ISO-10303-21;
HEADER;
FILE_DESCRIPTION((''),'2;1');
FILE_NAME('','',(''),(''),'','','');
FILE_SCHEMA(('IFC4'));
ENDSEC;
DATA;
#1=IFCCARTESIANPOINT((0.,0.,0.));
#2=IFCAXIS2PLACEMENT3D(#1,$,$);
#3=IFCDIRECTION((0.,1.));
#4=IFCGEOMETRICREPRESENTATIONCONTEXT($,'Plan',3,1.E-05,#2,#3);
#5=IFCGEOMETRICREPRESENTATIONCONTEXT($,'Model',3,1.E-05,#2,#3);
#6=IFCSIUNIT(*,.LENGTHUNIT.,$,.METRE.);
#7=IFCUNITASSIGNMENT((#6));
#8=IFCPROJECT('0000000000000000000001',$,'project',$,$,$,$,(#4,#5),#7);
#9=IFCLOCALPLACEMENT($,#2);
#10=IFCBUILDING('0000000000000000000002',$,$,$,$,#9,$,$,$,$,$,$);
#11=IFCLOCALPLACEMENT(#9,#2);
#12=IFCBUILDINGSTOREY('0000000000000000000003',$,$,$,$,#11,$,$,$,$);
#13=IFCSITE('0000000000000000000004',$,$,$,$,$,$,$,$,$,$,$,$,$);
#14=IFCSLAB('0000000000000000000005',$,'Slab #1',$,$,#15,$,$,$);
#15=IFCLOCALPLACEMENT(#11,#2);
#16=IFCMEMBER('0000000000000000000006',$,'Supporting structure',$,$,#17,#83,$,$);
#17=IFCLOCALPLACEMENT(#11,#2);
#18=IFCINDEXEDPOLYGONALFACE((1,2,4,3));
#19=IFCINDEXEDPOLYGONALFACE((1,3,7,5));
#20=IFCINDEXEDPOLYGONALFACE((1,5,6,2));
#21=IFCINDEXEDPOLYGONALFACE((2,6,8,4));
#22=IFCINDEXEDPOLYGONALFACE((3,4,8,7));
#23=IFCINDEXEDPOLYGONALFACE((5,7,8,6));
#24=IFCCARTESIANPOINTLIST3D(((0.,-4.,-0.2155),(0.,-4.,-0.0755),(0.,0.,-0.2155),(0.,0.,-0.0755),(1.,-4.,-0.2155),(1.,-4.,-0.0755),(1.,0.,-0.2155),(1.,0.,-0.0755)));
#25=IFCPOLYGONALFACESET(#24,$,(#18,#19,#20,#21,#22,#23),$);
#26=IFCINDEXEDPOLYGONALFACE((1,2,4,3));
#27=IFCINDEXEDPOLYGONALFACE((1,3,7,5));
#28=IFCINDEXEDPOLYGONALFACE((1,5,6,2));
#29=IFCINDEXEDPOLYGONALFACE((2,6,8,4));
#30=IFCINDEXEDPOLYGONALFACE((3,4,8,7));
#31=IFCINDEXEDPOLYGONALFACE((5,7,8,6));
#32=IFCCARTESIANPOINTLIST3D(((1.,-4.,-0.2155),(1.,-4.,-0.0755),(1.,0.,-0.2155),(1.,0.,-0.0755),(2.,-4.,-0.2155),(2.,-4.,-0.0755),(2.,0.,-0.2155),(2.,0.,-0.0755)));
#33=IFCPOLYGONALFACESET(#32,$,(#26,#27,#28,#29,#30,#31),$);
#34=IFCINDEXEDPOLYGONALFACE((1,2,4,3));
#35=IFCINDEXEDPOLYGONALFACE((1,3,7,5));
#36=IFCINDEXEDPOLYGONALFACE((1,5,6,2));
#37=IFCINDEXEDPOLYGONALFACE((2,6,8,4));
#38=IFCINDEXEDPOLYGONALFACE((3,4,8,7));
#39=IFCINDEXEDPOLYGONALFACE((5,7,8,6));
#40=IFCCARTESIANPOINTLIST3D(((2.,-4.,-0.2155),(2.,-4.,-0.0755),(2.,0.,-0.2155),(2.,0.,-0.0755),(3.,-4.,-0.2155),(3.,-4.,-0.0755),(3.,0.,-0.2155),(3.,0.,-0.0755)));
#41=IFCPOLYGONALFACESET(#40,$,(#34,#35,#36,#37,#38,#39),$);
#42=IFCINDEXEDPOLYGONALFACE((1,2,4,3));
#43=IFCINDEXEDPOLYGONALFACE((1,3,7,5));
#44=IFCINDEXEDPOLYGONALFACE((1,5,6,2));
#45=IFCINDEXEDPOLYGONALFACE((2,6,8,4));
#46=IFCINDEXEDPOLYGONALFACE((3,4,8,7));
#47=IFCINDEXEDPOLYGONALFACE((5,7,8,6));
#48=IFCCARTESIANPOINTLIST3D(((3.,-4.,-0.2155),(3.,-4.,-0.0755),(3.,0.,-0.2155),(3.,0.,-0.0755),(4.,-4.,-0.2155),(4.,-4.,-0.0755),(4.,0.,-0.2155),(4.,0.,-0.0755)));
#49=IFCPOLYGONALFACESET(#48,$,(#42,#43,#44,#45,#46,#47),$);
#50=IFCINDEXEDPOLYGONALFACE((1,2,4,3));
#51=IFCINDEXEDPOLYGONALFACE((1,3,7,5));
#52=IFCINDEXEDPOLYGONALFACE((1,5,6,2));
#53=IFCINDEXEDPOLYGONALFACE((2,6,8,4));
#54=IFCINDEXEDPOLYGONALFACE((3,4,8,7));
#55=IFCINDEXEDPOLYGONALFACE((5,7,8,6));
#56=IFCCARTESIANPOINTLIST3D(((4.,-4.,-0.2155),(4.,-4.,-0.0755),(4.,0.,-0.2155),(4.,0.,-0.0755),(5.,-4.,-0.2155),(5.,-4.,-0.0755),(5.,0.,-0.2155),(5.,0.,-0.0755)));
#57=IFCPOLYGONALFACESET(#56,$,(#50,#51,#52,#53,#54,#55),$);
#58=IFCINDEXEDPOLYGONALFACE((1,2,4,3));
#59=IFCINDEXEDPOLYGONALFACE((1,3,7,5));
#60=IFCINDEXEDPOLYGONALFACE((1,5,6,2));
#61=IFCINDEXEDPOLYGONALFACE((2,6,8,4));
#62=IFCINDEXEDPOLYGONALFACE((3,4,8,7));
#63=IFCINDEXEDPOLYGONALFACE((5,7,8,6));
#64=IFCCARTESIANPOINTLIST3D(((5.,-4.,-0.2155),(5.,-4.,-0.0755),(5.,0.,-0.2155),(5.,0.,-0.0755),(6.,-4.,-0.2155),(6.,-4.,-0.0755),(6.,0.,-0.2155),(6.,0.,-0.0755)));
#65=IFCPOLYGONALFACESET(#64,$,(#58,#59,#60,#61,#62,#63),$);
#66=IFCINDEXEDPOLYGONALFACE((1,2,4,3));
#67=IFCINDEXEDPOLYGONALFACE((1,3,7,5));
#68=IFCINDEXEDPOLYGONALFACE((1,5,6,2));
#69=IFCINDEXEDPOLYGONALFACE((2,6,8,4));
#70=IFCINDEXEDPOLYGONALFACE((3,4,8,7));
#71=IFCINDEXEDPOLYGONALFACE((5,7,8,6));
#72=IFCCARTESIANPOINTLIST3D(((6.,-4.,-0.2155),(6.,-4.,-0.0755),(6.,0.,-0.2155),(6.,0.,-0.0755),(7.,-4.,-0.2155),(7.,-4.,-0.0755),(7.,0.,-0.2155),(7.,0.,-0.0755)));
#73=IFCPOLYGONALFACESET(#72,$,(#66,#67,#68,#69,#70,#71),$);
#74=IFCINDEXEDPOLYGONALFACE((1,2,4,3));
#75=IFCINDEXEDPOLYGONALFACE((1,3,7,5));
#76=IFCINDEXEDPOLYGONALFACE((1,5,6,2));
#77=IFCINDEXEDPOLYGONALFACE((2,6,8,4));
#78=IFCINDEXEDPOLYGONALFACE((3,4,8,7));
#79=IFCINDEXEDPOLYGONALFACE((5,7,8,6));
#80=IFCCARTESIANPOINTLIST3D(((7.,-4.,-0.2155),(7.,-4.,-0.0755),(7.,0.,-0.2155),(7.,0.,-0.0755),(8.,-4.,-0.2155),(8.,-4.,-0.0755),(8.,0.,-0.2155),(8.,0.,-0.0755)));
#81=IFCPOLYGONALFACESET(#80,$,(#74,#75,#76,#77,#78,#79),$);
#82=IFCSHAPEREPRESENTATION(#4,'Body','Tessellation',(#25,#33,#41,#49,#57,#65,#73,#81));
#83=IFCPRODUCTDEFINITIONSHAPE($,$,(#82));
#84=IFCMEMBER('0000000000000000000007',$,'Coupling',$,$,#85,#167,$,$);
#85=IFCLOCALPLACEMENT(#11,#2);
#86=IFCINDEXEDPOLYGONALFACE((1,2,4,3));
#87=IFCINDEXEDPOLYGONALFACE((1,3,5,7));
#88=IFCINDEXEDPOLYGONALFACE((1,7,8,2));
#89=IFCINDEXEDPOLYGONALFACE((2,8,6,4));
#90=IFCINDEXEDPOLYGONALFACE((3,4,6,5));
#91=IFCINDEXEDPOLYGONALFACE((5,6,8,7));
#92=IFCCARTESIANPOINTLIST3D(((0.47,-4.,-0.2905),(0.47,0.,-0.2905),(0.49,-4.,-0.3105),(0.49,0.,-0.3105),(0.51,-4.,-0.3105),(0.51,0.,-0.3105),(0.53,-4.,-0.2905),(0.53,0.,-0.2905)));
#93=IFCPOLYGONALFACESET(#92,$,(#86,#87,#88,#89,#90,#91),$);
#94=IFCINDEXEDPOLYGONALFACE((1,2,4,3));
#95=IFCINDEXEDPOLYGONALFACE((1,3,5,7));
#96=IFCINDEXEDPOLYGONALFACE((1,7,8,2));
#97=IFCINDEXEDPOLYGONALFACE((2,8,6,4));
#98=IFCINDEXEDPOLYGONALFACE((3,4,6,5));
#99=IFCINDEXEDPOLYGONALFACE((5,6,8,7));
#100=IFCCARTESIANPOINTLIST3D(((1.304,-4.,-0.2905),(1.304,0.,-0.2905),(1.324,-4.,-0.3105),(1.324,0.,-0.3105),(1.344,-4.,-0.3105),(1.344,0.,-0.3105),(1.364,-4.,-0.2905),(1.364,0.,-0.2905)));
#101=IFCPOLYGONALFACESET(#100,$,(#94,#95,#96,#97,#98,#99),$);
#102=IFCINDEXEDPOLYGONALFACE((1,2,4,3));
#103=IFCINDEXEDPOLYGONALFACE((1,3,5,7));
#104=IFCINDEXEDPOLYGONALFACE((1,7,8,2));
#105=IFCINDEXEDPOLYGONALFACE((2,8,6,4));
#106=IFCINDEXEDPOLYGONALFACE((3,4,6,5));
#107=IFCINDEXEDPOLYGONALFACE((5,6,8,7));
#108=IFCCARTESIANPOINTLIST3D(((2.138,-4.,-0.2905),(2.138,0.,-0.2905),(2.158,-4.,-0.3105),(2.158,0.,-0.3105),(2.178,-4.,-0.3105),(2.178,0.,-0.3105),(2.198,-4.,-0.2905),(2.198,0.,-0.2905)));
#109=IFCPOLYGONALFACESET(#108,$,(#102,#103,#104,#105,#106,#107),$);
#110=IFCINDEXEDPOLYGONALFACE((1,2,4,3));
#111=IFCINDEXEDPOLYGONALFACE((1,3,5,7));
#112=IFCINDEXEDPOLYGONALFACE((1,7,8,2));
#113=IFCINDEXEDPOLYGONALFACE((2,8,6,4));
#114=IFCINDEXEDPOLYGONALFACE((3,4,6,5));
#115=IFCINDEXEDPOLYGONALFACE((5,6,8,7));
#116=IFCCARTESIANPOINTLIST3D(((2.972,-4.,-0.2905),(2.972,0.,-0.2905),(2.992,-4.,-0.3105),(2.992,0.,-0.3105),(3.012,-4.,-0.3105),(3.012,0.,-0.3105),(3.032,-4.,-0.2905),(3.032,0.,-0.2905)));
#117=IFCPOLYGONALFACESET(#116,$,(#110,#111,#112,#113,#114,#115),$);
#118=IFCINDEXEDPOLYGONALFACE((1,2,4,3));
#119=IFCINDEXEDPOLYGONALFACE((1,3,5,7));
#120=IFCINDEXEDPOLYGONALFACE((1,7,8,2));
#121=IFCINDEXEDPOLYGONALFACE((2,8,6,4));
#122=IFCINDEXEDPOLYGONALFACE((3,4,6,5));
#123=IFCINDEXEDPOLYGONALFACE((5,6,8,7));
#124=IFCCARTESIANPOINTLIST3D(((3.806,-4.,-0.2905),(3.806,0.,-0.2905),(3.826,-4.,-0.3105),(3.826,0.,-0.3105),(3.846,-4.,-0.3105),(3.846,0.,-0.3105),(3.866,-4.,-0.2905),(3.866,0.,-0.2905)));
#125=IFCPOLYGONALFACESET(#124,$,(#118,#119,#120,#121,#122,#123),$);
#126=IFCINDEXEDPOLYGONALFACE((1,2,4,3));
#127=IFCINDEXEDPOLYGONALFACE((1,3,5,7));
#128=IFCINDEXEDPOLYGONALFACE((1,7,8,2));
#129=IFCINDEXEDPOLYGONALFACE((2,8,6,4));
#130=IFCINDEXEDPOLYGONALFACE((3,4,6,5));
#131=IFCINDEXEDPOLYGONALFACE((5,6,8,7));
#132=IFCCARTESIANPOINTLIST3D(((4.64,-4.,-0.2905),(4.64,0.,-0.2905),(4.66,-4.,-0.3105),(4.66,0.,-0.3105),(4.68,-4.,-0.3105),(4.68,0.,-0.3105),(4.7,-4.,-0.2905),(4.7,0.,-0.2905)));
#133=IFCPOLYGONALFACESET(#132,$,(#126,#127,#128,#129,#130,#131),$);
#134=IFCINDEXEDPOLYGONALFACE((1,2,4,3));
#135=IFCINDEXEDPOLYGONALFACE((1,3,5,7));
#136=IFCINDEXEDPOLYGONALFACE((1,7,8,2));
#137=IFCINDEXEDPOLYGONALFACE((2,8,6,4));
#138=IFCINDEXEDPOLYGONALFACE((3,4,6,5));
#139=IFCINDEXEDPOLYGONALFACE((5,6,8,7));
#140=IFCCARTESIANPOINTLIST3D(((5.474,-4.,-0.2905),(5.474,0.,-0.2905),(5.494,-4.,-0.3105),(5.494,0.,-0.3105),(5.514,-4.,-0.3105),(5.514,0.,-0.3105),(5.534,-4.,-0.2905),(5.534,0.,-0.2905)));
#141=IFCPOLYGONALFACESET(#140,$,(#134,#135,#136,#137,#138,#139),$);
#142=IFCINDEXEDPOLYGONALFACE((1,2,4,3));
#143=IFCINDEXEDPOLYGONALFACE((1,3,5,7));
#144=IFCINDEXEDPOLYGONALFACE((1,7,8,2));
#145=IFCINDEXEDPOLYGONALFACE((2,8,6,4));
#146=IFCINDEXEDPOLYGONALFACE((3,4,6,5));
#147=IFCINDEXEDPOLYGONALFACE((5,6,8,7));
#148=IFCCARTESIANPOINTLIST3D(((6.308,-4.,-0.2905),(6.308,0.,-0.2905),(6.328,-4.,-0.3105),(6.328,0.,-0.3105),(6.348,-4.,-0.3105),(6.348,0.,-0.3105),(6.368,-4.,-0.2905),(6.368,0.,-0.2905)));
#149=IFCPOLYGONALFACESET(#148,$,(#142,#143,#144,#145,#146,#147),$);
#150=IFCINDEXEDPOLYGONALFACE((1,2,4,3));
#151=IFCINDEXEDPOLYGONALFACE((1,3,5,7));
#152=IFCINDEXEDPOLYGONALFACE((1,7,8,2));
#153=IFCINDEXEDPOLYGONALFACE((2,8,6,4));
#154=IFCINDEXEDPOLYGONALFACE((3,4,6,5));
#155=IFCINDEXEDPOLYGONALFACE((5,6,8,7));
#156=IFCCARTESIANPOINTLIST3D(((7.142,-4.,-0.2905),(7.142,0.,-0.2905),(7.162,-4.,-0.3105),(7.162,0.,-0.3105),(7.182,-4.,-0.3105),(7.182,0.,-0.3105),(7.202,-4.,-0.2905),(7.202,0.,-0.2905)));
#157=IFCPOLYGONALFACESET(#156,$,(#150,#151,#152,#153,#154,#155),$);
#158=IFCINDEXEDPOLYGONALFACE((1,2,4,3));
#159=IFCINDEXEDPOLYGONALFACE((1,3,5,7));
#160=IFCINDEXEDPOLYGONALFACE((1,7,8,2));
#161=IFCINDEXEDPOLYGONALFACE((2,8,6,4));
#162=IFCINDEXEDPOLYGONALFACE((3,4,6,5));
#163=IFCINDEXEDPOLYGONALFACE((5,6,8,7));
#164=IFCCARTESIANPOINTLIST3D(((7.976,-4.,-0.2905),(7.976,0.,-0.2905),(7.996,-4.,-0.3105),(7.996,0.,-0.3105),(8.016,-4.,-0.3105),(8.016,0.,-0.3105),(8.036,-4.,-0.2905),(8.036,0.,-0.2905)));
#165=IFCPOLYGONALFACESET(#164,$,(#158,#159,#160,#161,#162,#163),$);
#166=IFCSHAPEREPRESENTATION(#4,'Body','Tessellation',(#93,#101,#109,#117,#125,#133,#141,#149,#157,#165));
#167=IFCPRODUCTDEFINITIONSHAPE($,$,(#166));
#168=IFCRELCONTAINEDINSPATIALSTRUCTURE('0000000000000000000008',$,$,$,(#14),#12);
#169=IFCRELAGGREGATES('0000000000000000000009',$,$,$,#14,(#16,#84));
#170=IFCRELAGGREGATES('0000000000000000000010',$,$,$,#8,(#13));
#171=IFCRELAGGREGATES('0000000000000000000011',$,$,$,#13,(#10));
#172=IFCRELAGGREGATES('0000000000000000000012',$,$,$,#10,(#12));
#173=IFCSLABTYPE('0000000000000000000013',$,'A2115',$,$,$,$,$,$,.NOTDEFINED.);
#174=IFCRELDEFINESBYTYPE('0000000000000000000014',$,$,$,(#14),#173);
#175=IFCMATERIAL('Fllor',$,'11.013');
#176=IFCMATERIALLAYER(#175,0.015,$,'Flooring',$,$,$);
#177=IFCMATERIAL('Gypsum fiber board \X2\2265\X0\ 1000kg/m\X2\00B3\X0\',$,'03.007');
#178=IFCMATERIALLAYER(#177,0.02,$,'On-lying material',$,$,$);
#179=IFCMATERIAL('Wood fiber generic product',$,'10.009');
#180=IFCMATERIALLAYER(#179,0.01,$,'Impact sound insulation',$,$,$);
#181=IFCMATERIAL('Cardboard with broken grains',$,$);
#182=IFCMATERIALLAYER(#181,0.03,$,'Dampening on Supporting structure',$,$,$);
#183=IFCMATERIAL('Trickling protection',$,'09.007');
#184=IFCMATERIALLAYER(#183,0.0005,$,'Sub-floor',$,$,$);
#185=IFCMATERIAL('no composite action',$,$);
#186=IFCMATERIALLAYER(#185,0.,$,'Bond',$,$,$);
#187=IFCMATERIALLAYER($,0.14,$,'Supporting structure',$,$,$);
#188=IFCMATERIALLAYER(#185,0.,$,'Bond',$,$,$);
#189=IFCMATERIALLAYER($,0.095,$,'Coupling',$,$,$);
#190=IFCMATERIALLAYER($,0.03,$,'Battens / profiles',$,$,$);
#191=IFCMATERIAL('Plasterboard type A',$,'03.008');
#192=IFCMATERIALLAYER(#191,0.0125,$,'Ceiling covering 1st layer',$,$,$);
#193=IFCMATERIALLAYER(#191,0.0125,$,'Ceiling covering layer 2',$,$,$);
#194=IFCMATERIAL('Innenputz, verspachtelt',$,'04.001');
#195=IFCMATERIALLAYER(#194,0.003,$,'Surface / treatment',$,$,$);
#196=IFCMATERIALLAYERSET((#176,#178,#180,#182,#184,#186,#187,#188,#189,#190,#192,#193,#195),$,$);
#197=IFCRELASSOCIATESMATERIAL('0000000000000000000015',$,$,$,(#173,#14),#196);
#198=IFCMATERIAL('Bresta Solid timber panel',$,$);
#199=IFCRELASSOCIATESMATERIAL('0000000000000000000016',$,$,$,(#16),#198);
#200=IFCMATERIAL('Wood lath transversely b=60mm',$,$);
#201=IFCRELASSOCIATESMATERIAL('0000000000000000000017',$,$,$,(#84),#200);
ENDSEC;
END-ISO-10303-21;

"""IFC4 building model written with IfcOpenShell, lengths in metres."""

from ifc_helpers import new_model, si_unit, direction, frame, frame_2d, origin, place, context, project, spatial, polyline, rectangle, outline, extrude, material, layer, layer_set, type_object, element, aggregate, save


model = new_model("IFC4")

# Units and contexts
plan_context = context("Plan", 3, precision=1e-05, world=origin(), true_north=direction((0.0, 1.0)))
model_context = context("Model", 3, precision=1e-05, world=origin(), true_north=direction((0.0, 1.0)))
ifc_project = project(units=[si_unit("LENGTHUNIT", "METRE")], contexts=[plan_context, model_context])

# Site, building, storey
site = spatial("IfcSite", under=ifc_project)
building_placement = place(None, origin())
building = spatial("IfcBuilding", under=site, at=building_placement)
storey_placement = place(building_placement, origin())
storey = spatial("IfcBuildingStorey", under=building, at=storey_placement)

# Slab, members
ifc_material_1 = material(Name="Fllor", Category="11.013")
ifc_layer_1 = layer(ifc_material_1, 0.015, Name="Flooring")
ifc_material_2 = material(Name="Gypsum fiber board ≥ 1000kg/m³", Category="03.007")
ifc_layer_2 = layer(ifc_material_2, 0.02, Name="On-lying material")
ifc_material_3 = material(Name="Wood fiber generic product", Category="10.009")
ifc_layer_3 = layer(ifc_material_3, 0.01, Name="Impact sound insulation")
ifc_material_4 = material(Name="Cardboard with broken grains")
ifc_layer_4 = layer(ifc_material_4, 0.03, Name="Dampening on Supporting structure")
ifc_material_5 = material(Name="Trickling protection", Category="09.007")
ifc_layer_5 = layer(ifc_material_5, 0.0005, Name="Sub-floor")
ifc_material_6 = material(Name="no composite action")
ifc_layer_6 = layer(ifc_material_6, 0.0, Name="Bond")
ifc_layer_7 = layer(None, 0.14, Name="Supporting structure")
ifc_layer_8 = layer(ifc_material_6, 0.0, Name="Bond")
ifc_layer_9 = layer(None, 0.095, Name="Coupling")
ifc_layer_10 = layer(None, 0.03, Name="Battens / profiles")
ifc_material_7 = material(Name="Plasterboard type A", Category="03.008")
ifc_layer_11 = layer(ifc_material_7, 0.0125, Name="Ceiling covering 1st layer")
ifc_layer_12 = layer(ifc_material_7, 0.0125, Name="Ceiling covering layer 2")
ifc_material_8 = material(Name="Innenputz, verspachtelt", Category="04.001")
ifc_layer_13 = layer(ifc_material_8, 0.003, Name="Surface / treatment")
ifc_layer_set = layer_set([ifc_layer_1, ifc_layer_2, ifc_layer_3, ifc_layer_4, ifc_layer_5, ifc_layer_6, ifc_layer_7, ifc_layer_8, ifc_layer_9, ifc_layer_10, ifc_layer_11, ifc_layer_12, ifc_layer_13])
slab_type = type_object("IfcSlabType", Name="A2115", PredefinedType="NOTDEFINED", material=ifc_layer_set)
slab_placement = place(None, frame((0.0, 0.0, 0.0), z_axis=(0.0, 0.0, -1.0), x_axis=(1.0, 0.0, 0.0)))
slab = element("IfcSlab", 1, at=slab_placement, inside=storey, type_object=slab_type, material=ifc_layer_set, Name="Slab #1")
ifc_material_9 = material(Name="Bresta Solid timber panel")
member_1_placement = place(slab_placement, origin())
member_1 = element("IfcMember", 2, at=member_1_placement, material=ifc_material_9, Name="Supporting structure", context=plan_context, shape_type="SweptSolid", body=[
    extrude(rectangle(XDim=1.0, YDim=0.14, at=frame_2d((0.5, 0.07), x_axis=(1.0, 0.0))), frame((0.0, 4.0, 0.0755), z_axis=(0.0, -1.0, 0.0), x_axis=(1.0, 0.0, 0.0)), (0.0, 0.0, 1.0), 4.0),
    extrude(rectangle(XDim=1.0, YDim=0.14, at=frame_2d((0.5, 0.07), x_axis=(1.0, 0.0))), frame((1.0, 4.0, 0.0755), z_axis=(0.0, -1.0, 0.0), x_axis=(1.0, 0.0, 0.0)), (0.0, 0.0, 1.0), 4.0),
    extrude(rectangle(XDim=1.0, YDim=0.14, at=frame_2d((0.5, 0.07), x_axis=(1.0, 0.0))), frame((2.0, 4.0, 0.0755), z_axis=(0.0, -1.0, 0.0), x_axis=(1.0, 0.0, 0.0)), (0.0, 0.0, 1.0), 4.0),
    extrude(rectangle(XDim=1.0, YDim=0.14, at=frame_2d((0.5, 0.07), x_axis=(1.0, 0.0))), frame((3.0, 4.0, 0.0755), z_axis=(0.0, -1.0, 0.0), x_axis=(1.0, 0.0, 0.0)), (0.0, 0.0, 1.0), 4.0),
    extrude(rectangle(XDim=1.0, YDim=0.14, at=frame_2d((0.5, 0.07), x_axis=(1.0, 0.0))), frame((4.0, 4.0, 0.0755), z_axis=(0.0, -1.0, 0.0), x_axis=(1.0, 0.0, 0.0)), (0.0, 0.0, 1.0), 4.0),
    extrude(rectangle(XDim=1.0, YDim=0.14, at=frame_2d((0.5, 0.07), x_axis=(1.0, 0.0))), frame((5.0, 4.0, 0.0755), z_axis=(0.0, -1.0, 0.0), x_axis=(1.0, 0.0, 0.0)), (0.0, 0.0, 1.0), 4.0),
    extrude(rectangle(XDim=1.0, YDim=0.14, at=frame_2d((0.5, 0.07), x_axis=(1.0, 0.0))), frame((6.0, 4.0, 0.0755), z_axis=(0.0, -1.0, 0.0), x_axis=(1.0, 0.0, 0.0)), (0.0, 0.0, 1.0), 4.0),
    extrude(rectangle(XDim=1.0, YDim=0.14, at=frame_2d((0.5, 0.07), x_axis=(1.0, 0.0))), frame((7.0, 4.0, 0.0755), z_axis=(0.0, -1.0, 0.0), x_axis=(1.0, 0.0, 0.0)), (0.0, 0.0, 1.0), 4.0),
])
ifc_material_10 = material(Name="Wood lath transversely b=60mm")
member_2_placement = place(slab_placement, origin())
member_2 = element("IfcMember", 3, at=member_2_placement, material=ifc_material_10, Name="Coupling", context=plan_context, shape_type="SweptSolid", body=[
    extrude(outline(polyline([(0.0, 0.0), (0.06, 0.0), (0.04, 0.02), (0.02, 0.02), (0.0, 0.0)])), frame((0.47, 4.0, 0.2905), z_axis=(0.0, -1.0, 0.0), x_axis=(1.0, 0.0, 0.0)), (0.0, 0.0, 1.0), 4.0),
    extrude(outline(polyline([(0.0, 0.0), (0.06, 0.0), (0.04, 0.02), (0.02, 0.02), (0.0, 0.0)])), frame((1.304, 4.0, 0.2905), z_axis=(0.0, -1.0, 0.0), x_axis=(1.0, 0.0, 0.0)), (0.0, 0.0, 1.0), 4.0),
    extrude(outline(polyline([(0.0, 0.0), (0.06, 0.0), (0.04, 0.02), (0.02, 0.02), (0.0, 0.0)])), frame((2.138, 4.0, 0.2905), z_axis=(0.0, -1.0, 0.0), x_axis=(1.0, 0.0, 0.0)), (0.0, 0.0, 1.0), 4.0),
    extrude(outline(polyline([(0.0, 0.0), (0.06, 0.0), (0.04, 0.02), (0.02, 0.02), (0.0, 0.0)])), frame((2.972, 4.0, 0.2905), z_axis=(0.0, -1.0, 0.0), x_axis=(1.0, 0.0, 0.0)), (0.0, 0.0, 1.0), 4.0),
    extrude(outline(polyline([(0.0, 0.0), (0.06, 0.0), (0.04, 0.02), (0.02, 0.02), (0.0, 0.0)])), frame((3.806, 4.0, 0.2905), z_axis=(0.0, -1.0, 0.0), x_axis=(1.0, 0.0, 0.0)), (0.0, 0.0, 1.0), 4.0),
    extrude(outline(polyline([(0.0, 0.0), (0.06, 0.0), (0.04, 0.02), (0.02, 0.02), (0.0, 0.0)])), frame((4.64, 4.0, 0.2905), z_axis=(0.0, -1.0, 0.0), x_axis=(1.0, 0.0, 0.0)), (0.0, 0.0, 1.0), 4.0),
    extrude(outline(polyline([(0.0, 0.0), (0.06, 0.0), (0.04, 0.02), (0.02, 0.02), (0.0, 0.0)])), frame((5.474, 4.0, 0.2905), z_axis=(0.0, -1.0, 0.0), x_axis=(1.0, 0.0, 0.0)), (0.0, 0.0, 1.0), 4.0),
    extrude(outline(polyline([(0.0, 0.0), (0.06, 0.0), (0.04, 0.02), (0.02, 0.02), (0.0, 0.0)])), frame((6.308, 4.0, 0.2905), z_axis=(0.0, -1.0, 0.0), x_axis=(1.0, 0.0, 0.0)), (0.0, 0.0, 1.0), 4.0),
    extrude(outline(polyline([(0.0, 0.0), (0.06, 0.0), (0.04, 0.02), (0.02, 0.02), (0.0, 0.0)])), frame((7.142, 4.0, 0.2905), z_axis=(0.0, -1.0, 0.0), x_axis=(1.0, 0.0, 0.0)), (0.0, 0.0, 1.0), 4.0),
    extrude(outline(polyline([(0.0, 0.0), (0.06, 0.0), (0.04, 0.02), (0.02, 0.02), (0.0, 0.0)])), frame((7.976, 4.0, 0.2905), z_axis=(0.0, -1.0, 0.0), x_axis=(1.0, 0.0, 0.0)), (0.0, 0.0, 1.0), 4.0),
])
aggregate(slab, [member_1, member_2])

save(model, "model.ifc")
